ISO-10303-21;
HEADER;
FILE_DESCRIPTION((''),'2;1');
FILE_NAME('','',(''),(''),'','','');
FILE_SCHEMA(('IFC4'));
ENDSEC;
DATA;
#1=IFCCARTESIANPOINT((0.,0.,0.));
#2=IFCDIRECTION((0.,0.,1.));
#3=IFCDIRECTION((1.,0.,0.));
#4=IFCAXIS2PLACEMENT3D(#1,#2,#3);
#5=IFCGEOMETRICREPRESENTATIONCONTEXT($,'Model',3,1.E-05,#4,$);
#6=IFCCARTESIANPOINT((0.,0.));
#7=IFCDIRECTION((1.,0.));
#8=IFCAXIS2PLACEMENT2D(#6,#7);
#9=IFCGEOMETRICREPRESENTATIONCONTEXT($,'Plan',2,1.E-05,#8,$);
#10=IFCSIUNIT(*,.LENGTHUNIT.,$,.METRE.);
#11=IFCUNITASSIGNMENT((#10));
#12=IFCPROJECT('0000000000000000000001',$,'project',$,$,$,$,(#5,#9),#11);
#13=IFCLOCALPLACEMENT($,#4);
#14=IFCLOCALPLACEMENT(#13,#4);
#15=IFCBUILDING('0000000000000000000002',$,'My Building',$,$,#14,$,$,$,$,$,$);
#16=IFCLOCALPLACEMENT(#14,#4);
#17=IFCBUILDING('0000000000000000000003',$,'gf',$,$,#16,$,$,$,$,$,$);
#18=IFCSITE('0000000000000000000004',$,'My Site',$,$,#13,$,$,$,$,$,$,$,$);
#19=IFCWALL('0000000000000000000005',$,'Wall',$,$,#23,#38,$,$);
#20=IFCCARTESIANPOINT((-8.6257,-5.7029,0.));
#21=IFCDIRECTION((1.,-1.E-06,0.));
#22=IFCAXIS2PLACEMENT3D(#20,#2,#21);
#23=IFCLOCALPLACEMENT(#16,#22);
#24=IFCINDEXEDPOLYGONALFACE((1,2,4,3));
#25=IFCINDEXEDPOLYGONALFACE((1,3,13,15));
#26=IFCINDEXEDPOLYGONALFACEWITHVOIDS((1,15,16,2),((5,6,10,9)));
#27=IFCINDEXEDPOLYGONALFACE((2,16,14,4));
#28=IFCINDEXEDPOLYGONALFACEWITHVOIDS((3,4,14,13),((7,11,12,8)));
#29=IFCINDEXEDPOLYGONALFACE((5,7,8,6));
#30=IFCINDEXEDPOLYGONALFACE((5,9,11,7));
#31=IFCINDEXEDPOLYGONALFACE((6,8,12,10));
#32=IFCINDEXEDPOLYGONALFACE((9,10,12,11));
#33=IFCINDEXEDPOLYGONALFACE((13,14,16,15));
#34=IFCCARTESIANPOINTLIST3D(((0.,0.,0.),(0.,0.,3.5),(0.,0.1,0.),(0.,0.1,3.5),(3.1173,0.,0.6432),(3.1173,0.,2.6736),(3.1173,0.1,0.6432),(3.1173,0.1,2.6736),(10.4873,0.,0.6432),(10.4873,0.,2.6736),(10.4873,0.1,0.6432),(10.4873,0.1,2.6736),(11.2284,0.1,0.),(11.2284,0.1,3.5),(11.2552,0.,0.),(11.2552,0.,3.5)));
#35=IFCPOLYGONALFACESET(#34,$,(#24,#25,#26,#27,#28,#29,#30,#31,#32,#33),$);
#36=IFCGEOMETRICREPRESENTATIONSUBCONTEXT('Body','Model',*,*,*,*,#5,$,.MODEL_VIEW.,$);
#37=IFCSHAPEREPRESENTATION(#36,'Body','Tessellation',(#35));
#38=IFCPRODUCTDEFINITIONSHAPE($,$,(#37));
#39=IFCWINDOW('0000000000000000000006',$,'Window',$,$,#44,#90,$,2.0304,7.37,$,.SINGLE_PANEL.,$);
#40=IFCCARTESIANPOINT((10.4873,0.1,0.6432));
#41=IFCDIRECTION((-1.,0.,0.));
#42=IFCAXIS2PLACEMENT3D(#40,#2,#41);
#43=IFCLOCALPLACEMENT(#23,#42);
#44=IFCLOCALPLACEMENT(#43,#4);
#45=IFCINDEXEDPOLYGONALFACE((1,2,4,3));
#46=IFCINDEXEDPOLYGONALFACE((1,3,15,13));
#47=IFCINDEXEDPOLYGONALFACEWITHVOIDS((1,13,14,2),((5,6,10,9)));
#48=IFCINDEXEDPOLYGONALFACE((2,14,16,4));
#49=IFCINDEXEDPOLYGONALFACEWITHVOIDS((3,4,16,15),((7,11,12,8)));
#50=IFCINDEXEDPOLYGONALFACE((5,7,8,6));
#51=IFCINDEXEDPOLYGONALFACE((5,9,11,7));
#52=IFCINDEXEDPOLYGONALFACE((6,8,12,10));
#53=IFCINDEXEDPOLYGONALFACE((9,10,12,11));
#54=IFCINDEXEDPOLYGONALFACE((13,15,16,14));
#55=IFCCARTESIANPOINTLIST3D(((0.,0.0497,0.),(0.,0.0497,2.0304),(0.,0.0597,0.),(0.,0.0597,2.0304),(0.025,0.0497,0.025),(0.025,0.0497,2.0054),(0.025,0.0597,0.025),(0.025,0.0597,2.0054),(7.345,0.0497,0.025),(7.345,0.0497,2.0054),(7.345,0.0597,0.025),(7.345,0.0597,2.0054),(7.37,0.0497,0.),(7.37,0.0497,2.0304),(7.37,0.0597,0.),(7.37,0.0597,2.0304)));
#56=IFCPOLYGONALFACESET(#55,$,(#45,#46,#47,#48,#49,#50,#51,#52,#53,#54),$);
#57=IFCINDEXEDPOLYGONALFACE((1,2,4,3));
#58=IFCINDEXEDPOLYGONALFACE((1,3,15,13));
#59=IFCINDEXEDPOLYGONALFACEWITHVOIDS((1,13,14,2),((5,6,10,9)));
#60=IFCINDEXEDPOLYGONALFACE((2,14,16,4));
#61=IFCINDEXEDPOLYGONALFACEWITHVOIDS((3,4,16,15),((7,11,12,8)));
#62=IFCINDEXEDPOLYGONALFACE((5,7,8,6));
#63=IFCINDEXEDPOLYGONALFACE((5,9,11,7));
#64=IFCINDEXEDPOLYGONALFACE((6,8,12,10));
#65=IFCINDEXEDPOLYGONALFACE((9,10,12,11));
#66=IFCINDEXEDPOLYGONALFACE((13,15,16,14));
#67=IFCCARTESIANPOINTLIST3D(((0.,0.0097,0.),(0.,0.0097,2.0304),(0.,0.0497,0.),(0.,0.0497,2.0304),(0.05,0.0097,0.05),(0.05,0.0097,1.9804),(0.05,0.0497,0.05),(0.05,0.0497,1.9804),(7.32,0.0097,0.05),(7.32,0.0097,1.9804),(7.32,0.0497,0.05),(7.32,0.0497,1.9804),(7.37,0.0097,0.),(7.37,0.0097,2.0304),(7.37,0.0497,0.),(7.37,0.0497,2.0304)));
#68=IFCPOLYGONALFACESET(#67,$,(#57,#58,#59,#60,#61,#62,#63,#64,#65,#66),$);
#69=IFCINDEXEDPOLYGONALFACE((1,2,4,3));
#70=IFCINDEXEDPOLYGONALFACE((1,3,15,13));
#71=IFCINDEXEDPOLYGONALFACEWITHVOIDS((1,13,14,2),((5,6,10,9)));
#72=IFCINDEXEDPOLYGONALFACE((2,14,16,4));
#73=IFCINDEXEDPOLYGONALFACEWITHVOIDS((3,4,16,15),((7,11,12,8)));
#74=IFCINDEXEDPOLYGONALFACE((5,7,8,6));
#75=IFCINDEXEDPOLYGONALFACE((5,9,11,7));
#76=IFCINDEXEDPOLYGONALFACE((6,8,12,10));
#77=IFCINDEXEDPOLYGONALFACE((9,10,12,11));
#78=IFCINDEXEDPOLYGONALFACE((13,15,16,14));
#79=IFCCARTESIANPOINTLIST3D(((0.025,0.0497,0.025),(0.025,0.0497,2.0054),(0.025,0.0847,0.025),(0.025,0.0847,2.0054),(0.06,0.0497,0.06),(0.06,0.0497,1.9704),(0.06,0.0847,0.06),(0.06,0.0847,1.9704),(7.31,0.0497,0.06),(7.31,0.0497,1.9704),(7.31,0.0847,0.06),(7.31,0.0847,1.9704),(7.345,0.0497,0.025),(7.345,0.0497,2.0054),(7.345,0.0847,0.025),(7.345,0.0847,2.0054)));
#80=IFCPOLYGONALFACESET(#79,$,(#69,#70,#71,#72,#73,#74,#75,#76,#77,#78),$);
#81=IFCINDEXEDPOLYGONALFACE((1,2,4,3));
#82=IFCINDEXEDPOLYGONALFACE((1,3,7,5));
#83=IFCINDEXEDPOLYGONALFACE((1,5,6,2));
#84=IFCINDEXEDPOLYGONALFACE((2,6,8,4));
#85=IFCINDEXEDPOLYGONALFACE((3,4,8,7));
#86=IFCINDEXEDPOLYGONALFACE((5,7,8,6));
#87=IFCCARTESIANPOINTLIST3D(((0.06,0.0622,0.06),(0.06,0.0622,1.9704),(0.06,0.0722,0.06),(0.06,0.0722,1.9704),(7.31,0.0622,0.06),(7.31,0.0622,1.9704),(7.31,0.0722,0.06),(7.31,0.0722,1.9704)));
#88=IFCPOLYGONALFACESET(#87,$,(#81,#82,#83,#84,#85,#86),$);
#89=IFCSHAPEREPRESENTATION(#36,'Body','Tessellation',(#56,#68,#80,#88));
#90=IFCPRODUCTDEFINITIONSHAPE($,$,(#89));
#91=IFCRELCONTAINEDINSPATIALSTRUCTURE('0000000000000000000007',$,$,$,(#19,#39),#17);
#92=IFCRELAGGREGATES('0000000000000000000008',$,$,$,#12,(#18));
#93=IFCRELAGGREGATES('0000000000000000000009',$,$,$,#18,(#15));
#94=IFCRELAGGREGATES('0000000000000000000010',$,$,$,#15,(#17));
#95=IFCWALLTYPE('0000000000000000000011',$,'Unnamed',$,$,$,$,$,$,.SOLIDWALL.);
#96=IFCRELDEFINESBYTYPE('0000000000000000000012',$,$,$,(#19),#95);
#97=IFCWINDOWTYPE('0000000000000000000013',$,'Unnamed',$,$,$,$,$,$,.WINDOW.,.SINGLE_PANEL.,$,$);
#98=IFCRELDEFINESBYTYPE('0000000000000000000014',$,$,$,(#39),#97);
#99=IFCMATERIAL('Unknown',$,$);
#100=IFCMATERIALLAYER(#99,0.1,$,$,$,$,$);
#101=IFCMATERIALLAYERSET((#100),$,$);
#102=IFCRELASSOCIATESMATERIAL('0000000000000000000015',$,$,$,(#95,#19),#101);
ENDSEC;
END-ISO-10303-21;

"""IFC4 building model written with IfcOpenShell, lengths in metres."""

from ifc_helpers import new_model, entity, si_unit, frame, origin_with_axes, origin_2d_with_axis, place, context, subcontext, project, spatial, line, indexed_curve, outline, extrude, shape, source, transform, mapped, material, layer, layer_set, layer_usage, type_object, type_shapes, element, fill, save


model = new_model("IFC4")

# Units and contexts
model_context = context("Model", 3, precision=1e-05, world=origin_with_axes())
plan_context = context("Plan", 2, precision=1e-05, world=origin_2d_with_axis())
body_context_1 = subcontext(model_context, "Body", "Model", "MODEL_VIEW")
body_context_2 = subcontext(plan_context, "Body", "Plan", "PLAN_VIEW")
ifc_project = project(units=[si_unit("LENGTHUNIT", "METRE")], contexts=[model_context, plan_context])

# Site, buildings
site_placement = place(None, origin_with_axes())
site = spatial("IfcSite", under=ifc_project, at=site_placement, Name="My Site")
building_1_placement = place(site_placement, origin_with_axes())
building_1 = spatial("IfcBuilding", under=site, at=building_1_placement, Name="My Building")
building_2_placement = place(building_1_placement, origin_with_axes())
building_2 = spatial("IfcBuilding", under=building_1, at=building_2_placement, Name="gf")

# Shared definitions
ifc_material = material(Name="Unknown")

# Shared definitions
ifc_layer_1 = layer(ifc_material, 0.1)
ifc_layer_set_1 = layer_set([ifc_layer_1])
wall_type = type_object("IfcWallType", Name="Unnamed", PredefinedType="SOLIDWALL", material=ifc_layer_set_1)

# Wall, opening, window
ifc_layer_usage_1 = layer_usage(ifc_layer_set_1, "AXIS2", "POSITIVE", 0.0)
wall_1_placement = place(building_2_placement, frame((-8.6257, -5.7029, 0.0), z_axis=(0.0, 0.0, 1.0), x_axis=(1.0, -0.000001, 0.0)))
wall_1 = element("IfcWall", 1, at=wall_1_placement, inside=building_2, type_object=wall_type, material=ifc_layer_usage_1, Name="Wall", context=body_context_1, shape_type="SweptSolid", body=[
    extrude(outline(indexed_curve([(0.0, 0.0), (0.0, 0.1), (11.2284, 0.1), (11.2552, 0.0)], segments=[line(1, 2, 3, 4, 1)])), origin_with_axes(), (0.0, 0.0, 1.0), 3.5),
])
shared_shape_1 = source(origin_with_axes(), body_context_1, "Body", "SweptSolid", [
    extrude(outline(indexed_curve([(0.0, 0.0), (7.37, 0.0), (7.37, 2.0304), (0.0, 2.0304)], segments=[line(1, 2, 3, 4, 1)])), frame((0.0, -0.6, 0.0), z_axis=(0.0, -1.0, 0.0), x_axis=(1.0, 0.0, 0.0)), (0.0, 0.0, -1.0), 1.2),
])
opening_1_placement = place(wall_1_placement, frame((10.4873, 0.1, 0.6432), z_axis=(0.0, 0.0, 1.0), x_axis=(-1.0, 0.0, 0.0)))
opening_1 = element("IfcOpeningElement", 2, at=opening_1_placement, cuts=wall_1, PredefinedType="OPENING", context=body_context_1, shape_type="MappedRepresentation", body=[
    mapped(shared_shape_1, transform((0.0, 0.0, 0.0), x_axis=(1.0, 0.0, 0.0), y_axis=(0.0, 1.0, 0.0), z_axis=(0.0, 0.0, 1.0), scale=1.0)),
])
window_type_1 = type_object("IfcWindowType", Name="Unnamed", PartitioningType="SINGLE_PANEL", PredefinedType="WINDOW")
shared_shape_2 = source(origin_with_axes(), body_context_1, "Body", "SweptSolid", [
    extrude(outline(indexed_curve([(0.0, 0.0), (7.37, 0.0), (7.37, 2.0304), (0.0, 2.0304)], segments=[line(1, 2, 3, 4, 1)]), holes=[indexed_curve([(0.025, 0.025), (7.345, 0.025), (7.345, 2.0054), (0.025, 2.0054)], segments=[line(1, 2, 3, 4, 1)])]), frame((0.0, 0.0497, 0.0), z_axis=(0.0, -1.0, 0.0), x_axis=(1.0, 0.0, 0.0)), (0.0, 0.0, -1.0), 0.01),
    extrude(outline(indexed_curve([(0.0, 0.0), (7.37, 0.0), (7.37, 2.0304), (0.0, 2.0304)], segments=[line(1, 2, 3, 4, 1)]), holes=[indexed_curve([(0.05, 0.05), (7.32, 0.05), (7.32, 1.9804), (0.05, 1.9804)], segments=[line(1, 2, 3, 4, 1)])]), frame((0.0, 0.0097, 0.0), z_axis=(0.0, -1.0, 0.0), x_axis=(1.0, 0.0, 0.0)), (0.0, 0.0, -1.0), 0.04),
    extrude(outline(indexed_curve([(0.0, 0.0), (7.32, 0.0), (7.32, 1.9804), (0.0, 1.9804)], segments=[line(1, 2, 3, 4, 1)]), holes=[indexed_curve([(0.035, 0.035), (7.285, 0.035), (7.285, 1.9454), (0.035, 1.9454)], segments=[line(1, 2, 3, 4, 1)])]), frame((0.025, 0.0497, 0.025), z_axis=(0.0, -1.0, 0.0), x_axis=(1.0, 0.0, 0.0)), (0.0, 0.0, -1.0), 0.035),
    extrude(outline(indexed_curve([(0.035, 0.035), (7.285, 0.035), (7.285, 1.9454), (0.035, 1.9454)], segments=[line(1, 2, 3, 4, 1)])), frame((0.025, 0.0622, 0.025), z_axis=(0.0, -1.0, 0.0), x_axis=(1.0, 0.0, 0.0)), (0.0, 0.0, -1.0), 0.01),
])
shared_shape_3 = source(origin_with_axes(), body_context_2, "Body", "Curve2D", [
    entity("IfcIndexedPolyCurve", entity("IfcCartesianPointList2D", [[0.05, 0.0097], [7.32, 0.0097]])),
    entity("IfcIndexedPolyCurve", entity("IfcCartesianPointList2D", [[0.0, 0.0597], [0.025, 0.0597], [0.025, 0.0497], [0.05, 0.0497], [0.05, 0.0097], [0.0, 0.0097]]), [entity("IfcLineIndex", [1, 2, 3, 4, 5, 6, 1])]),
    entity("IfcIndexedPolyCurve", entity("IfcCartesianPointList2D", [[7.37, 0.0597], [7.345, 0.0597], [7.345, 0.0497], [7.32, 0.0497], [7.32, 0.0097], [7.37, 0.0097]]), [entity("IfcLineIndex", [1, 2, 3, 4, 5, 6, 1])]),
    entity("IfcIndexedPolyCurve", entity("IfcCartesianPointList2D", [[0.025, 0.0497], [0.06, 0.0497], [0.06, 0.0847], [0.025, 0.0847]]), [entity("IfcLineIndex", [1, 2, 3, 4, 1])]),
    entity("IfcIndexedPolyCurve", entity("IfcCartesianPointList2D", [[7.345, 0.0497], [7.31, 0.0497], [7.31, 0.0847], [7.345, 0.0847]]), [entity("IfcLineIndex", [1, 2, 3, 4, 1])]),
    entity("IfcIndexedPolyCurve", entity("IfcCartesianPointList2D", [[0.06, 0.0497], [7.31, 0.0497]])),
    entity("IfcIndexedPolyCurve", entity("IfcCartesianPointList2D", [[0.06, 0.0847], [7.31, 0.0847]])),
    entity("IfcIndexedPolyCurve", entity("IfcCartesianPointList2D", [[0.06, 0.0672], [7.31, 0.0672]])),
])
type_shapes(window_type_1, [shared_shape_2, shared_shape_3])
window_1_placement = place(opening_1_placement, frame((0.0, 0.0, 0.0), z_axis=(0.0, 0.0, 1.0), x_axis=(1.0, 0.0, 0.0)))
window_1 = element("IfcWindow", 3, at=window_1_placement, inside=building_2, type_object=window_type_1, Name="Window", OverallHeight=2.0304, OverallWidth=7.37, PartitioningType="SINGLE_PANEL", shapes=[
    shape(body_context_1, "Body", "MappedRepresentation", [mapped(shared_shape_2, transform((0.0, 0.0, 0.0), x_axis=(1.0, 0.0, 0.0), y_axis=(0.0, 1.0, 0.0), z_axis=(0.0, 0.0, 1.0), scale=1.0))]),
    shape(body_context_2, "Body", "MappedRepresentation", [mapped(shared_shape_3, transform((0.0, 0.0, 0.0), x_axis=(1.0, 0.0, 0.0), y_axis=(0.0, 1.0, 0.0), z_axis=(0.0, 0.0, 1.0), scale=1.0))]),
])
fill(opening_1, window_1)

save(model, "model.ifc")
